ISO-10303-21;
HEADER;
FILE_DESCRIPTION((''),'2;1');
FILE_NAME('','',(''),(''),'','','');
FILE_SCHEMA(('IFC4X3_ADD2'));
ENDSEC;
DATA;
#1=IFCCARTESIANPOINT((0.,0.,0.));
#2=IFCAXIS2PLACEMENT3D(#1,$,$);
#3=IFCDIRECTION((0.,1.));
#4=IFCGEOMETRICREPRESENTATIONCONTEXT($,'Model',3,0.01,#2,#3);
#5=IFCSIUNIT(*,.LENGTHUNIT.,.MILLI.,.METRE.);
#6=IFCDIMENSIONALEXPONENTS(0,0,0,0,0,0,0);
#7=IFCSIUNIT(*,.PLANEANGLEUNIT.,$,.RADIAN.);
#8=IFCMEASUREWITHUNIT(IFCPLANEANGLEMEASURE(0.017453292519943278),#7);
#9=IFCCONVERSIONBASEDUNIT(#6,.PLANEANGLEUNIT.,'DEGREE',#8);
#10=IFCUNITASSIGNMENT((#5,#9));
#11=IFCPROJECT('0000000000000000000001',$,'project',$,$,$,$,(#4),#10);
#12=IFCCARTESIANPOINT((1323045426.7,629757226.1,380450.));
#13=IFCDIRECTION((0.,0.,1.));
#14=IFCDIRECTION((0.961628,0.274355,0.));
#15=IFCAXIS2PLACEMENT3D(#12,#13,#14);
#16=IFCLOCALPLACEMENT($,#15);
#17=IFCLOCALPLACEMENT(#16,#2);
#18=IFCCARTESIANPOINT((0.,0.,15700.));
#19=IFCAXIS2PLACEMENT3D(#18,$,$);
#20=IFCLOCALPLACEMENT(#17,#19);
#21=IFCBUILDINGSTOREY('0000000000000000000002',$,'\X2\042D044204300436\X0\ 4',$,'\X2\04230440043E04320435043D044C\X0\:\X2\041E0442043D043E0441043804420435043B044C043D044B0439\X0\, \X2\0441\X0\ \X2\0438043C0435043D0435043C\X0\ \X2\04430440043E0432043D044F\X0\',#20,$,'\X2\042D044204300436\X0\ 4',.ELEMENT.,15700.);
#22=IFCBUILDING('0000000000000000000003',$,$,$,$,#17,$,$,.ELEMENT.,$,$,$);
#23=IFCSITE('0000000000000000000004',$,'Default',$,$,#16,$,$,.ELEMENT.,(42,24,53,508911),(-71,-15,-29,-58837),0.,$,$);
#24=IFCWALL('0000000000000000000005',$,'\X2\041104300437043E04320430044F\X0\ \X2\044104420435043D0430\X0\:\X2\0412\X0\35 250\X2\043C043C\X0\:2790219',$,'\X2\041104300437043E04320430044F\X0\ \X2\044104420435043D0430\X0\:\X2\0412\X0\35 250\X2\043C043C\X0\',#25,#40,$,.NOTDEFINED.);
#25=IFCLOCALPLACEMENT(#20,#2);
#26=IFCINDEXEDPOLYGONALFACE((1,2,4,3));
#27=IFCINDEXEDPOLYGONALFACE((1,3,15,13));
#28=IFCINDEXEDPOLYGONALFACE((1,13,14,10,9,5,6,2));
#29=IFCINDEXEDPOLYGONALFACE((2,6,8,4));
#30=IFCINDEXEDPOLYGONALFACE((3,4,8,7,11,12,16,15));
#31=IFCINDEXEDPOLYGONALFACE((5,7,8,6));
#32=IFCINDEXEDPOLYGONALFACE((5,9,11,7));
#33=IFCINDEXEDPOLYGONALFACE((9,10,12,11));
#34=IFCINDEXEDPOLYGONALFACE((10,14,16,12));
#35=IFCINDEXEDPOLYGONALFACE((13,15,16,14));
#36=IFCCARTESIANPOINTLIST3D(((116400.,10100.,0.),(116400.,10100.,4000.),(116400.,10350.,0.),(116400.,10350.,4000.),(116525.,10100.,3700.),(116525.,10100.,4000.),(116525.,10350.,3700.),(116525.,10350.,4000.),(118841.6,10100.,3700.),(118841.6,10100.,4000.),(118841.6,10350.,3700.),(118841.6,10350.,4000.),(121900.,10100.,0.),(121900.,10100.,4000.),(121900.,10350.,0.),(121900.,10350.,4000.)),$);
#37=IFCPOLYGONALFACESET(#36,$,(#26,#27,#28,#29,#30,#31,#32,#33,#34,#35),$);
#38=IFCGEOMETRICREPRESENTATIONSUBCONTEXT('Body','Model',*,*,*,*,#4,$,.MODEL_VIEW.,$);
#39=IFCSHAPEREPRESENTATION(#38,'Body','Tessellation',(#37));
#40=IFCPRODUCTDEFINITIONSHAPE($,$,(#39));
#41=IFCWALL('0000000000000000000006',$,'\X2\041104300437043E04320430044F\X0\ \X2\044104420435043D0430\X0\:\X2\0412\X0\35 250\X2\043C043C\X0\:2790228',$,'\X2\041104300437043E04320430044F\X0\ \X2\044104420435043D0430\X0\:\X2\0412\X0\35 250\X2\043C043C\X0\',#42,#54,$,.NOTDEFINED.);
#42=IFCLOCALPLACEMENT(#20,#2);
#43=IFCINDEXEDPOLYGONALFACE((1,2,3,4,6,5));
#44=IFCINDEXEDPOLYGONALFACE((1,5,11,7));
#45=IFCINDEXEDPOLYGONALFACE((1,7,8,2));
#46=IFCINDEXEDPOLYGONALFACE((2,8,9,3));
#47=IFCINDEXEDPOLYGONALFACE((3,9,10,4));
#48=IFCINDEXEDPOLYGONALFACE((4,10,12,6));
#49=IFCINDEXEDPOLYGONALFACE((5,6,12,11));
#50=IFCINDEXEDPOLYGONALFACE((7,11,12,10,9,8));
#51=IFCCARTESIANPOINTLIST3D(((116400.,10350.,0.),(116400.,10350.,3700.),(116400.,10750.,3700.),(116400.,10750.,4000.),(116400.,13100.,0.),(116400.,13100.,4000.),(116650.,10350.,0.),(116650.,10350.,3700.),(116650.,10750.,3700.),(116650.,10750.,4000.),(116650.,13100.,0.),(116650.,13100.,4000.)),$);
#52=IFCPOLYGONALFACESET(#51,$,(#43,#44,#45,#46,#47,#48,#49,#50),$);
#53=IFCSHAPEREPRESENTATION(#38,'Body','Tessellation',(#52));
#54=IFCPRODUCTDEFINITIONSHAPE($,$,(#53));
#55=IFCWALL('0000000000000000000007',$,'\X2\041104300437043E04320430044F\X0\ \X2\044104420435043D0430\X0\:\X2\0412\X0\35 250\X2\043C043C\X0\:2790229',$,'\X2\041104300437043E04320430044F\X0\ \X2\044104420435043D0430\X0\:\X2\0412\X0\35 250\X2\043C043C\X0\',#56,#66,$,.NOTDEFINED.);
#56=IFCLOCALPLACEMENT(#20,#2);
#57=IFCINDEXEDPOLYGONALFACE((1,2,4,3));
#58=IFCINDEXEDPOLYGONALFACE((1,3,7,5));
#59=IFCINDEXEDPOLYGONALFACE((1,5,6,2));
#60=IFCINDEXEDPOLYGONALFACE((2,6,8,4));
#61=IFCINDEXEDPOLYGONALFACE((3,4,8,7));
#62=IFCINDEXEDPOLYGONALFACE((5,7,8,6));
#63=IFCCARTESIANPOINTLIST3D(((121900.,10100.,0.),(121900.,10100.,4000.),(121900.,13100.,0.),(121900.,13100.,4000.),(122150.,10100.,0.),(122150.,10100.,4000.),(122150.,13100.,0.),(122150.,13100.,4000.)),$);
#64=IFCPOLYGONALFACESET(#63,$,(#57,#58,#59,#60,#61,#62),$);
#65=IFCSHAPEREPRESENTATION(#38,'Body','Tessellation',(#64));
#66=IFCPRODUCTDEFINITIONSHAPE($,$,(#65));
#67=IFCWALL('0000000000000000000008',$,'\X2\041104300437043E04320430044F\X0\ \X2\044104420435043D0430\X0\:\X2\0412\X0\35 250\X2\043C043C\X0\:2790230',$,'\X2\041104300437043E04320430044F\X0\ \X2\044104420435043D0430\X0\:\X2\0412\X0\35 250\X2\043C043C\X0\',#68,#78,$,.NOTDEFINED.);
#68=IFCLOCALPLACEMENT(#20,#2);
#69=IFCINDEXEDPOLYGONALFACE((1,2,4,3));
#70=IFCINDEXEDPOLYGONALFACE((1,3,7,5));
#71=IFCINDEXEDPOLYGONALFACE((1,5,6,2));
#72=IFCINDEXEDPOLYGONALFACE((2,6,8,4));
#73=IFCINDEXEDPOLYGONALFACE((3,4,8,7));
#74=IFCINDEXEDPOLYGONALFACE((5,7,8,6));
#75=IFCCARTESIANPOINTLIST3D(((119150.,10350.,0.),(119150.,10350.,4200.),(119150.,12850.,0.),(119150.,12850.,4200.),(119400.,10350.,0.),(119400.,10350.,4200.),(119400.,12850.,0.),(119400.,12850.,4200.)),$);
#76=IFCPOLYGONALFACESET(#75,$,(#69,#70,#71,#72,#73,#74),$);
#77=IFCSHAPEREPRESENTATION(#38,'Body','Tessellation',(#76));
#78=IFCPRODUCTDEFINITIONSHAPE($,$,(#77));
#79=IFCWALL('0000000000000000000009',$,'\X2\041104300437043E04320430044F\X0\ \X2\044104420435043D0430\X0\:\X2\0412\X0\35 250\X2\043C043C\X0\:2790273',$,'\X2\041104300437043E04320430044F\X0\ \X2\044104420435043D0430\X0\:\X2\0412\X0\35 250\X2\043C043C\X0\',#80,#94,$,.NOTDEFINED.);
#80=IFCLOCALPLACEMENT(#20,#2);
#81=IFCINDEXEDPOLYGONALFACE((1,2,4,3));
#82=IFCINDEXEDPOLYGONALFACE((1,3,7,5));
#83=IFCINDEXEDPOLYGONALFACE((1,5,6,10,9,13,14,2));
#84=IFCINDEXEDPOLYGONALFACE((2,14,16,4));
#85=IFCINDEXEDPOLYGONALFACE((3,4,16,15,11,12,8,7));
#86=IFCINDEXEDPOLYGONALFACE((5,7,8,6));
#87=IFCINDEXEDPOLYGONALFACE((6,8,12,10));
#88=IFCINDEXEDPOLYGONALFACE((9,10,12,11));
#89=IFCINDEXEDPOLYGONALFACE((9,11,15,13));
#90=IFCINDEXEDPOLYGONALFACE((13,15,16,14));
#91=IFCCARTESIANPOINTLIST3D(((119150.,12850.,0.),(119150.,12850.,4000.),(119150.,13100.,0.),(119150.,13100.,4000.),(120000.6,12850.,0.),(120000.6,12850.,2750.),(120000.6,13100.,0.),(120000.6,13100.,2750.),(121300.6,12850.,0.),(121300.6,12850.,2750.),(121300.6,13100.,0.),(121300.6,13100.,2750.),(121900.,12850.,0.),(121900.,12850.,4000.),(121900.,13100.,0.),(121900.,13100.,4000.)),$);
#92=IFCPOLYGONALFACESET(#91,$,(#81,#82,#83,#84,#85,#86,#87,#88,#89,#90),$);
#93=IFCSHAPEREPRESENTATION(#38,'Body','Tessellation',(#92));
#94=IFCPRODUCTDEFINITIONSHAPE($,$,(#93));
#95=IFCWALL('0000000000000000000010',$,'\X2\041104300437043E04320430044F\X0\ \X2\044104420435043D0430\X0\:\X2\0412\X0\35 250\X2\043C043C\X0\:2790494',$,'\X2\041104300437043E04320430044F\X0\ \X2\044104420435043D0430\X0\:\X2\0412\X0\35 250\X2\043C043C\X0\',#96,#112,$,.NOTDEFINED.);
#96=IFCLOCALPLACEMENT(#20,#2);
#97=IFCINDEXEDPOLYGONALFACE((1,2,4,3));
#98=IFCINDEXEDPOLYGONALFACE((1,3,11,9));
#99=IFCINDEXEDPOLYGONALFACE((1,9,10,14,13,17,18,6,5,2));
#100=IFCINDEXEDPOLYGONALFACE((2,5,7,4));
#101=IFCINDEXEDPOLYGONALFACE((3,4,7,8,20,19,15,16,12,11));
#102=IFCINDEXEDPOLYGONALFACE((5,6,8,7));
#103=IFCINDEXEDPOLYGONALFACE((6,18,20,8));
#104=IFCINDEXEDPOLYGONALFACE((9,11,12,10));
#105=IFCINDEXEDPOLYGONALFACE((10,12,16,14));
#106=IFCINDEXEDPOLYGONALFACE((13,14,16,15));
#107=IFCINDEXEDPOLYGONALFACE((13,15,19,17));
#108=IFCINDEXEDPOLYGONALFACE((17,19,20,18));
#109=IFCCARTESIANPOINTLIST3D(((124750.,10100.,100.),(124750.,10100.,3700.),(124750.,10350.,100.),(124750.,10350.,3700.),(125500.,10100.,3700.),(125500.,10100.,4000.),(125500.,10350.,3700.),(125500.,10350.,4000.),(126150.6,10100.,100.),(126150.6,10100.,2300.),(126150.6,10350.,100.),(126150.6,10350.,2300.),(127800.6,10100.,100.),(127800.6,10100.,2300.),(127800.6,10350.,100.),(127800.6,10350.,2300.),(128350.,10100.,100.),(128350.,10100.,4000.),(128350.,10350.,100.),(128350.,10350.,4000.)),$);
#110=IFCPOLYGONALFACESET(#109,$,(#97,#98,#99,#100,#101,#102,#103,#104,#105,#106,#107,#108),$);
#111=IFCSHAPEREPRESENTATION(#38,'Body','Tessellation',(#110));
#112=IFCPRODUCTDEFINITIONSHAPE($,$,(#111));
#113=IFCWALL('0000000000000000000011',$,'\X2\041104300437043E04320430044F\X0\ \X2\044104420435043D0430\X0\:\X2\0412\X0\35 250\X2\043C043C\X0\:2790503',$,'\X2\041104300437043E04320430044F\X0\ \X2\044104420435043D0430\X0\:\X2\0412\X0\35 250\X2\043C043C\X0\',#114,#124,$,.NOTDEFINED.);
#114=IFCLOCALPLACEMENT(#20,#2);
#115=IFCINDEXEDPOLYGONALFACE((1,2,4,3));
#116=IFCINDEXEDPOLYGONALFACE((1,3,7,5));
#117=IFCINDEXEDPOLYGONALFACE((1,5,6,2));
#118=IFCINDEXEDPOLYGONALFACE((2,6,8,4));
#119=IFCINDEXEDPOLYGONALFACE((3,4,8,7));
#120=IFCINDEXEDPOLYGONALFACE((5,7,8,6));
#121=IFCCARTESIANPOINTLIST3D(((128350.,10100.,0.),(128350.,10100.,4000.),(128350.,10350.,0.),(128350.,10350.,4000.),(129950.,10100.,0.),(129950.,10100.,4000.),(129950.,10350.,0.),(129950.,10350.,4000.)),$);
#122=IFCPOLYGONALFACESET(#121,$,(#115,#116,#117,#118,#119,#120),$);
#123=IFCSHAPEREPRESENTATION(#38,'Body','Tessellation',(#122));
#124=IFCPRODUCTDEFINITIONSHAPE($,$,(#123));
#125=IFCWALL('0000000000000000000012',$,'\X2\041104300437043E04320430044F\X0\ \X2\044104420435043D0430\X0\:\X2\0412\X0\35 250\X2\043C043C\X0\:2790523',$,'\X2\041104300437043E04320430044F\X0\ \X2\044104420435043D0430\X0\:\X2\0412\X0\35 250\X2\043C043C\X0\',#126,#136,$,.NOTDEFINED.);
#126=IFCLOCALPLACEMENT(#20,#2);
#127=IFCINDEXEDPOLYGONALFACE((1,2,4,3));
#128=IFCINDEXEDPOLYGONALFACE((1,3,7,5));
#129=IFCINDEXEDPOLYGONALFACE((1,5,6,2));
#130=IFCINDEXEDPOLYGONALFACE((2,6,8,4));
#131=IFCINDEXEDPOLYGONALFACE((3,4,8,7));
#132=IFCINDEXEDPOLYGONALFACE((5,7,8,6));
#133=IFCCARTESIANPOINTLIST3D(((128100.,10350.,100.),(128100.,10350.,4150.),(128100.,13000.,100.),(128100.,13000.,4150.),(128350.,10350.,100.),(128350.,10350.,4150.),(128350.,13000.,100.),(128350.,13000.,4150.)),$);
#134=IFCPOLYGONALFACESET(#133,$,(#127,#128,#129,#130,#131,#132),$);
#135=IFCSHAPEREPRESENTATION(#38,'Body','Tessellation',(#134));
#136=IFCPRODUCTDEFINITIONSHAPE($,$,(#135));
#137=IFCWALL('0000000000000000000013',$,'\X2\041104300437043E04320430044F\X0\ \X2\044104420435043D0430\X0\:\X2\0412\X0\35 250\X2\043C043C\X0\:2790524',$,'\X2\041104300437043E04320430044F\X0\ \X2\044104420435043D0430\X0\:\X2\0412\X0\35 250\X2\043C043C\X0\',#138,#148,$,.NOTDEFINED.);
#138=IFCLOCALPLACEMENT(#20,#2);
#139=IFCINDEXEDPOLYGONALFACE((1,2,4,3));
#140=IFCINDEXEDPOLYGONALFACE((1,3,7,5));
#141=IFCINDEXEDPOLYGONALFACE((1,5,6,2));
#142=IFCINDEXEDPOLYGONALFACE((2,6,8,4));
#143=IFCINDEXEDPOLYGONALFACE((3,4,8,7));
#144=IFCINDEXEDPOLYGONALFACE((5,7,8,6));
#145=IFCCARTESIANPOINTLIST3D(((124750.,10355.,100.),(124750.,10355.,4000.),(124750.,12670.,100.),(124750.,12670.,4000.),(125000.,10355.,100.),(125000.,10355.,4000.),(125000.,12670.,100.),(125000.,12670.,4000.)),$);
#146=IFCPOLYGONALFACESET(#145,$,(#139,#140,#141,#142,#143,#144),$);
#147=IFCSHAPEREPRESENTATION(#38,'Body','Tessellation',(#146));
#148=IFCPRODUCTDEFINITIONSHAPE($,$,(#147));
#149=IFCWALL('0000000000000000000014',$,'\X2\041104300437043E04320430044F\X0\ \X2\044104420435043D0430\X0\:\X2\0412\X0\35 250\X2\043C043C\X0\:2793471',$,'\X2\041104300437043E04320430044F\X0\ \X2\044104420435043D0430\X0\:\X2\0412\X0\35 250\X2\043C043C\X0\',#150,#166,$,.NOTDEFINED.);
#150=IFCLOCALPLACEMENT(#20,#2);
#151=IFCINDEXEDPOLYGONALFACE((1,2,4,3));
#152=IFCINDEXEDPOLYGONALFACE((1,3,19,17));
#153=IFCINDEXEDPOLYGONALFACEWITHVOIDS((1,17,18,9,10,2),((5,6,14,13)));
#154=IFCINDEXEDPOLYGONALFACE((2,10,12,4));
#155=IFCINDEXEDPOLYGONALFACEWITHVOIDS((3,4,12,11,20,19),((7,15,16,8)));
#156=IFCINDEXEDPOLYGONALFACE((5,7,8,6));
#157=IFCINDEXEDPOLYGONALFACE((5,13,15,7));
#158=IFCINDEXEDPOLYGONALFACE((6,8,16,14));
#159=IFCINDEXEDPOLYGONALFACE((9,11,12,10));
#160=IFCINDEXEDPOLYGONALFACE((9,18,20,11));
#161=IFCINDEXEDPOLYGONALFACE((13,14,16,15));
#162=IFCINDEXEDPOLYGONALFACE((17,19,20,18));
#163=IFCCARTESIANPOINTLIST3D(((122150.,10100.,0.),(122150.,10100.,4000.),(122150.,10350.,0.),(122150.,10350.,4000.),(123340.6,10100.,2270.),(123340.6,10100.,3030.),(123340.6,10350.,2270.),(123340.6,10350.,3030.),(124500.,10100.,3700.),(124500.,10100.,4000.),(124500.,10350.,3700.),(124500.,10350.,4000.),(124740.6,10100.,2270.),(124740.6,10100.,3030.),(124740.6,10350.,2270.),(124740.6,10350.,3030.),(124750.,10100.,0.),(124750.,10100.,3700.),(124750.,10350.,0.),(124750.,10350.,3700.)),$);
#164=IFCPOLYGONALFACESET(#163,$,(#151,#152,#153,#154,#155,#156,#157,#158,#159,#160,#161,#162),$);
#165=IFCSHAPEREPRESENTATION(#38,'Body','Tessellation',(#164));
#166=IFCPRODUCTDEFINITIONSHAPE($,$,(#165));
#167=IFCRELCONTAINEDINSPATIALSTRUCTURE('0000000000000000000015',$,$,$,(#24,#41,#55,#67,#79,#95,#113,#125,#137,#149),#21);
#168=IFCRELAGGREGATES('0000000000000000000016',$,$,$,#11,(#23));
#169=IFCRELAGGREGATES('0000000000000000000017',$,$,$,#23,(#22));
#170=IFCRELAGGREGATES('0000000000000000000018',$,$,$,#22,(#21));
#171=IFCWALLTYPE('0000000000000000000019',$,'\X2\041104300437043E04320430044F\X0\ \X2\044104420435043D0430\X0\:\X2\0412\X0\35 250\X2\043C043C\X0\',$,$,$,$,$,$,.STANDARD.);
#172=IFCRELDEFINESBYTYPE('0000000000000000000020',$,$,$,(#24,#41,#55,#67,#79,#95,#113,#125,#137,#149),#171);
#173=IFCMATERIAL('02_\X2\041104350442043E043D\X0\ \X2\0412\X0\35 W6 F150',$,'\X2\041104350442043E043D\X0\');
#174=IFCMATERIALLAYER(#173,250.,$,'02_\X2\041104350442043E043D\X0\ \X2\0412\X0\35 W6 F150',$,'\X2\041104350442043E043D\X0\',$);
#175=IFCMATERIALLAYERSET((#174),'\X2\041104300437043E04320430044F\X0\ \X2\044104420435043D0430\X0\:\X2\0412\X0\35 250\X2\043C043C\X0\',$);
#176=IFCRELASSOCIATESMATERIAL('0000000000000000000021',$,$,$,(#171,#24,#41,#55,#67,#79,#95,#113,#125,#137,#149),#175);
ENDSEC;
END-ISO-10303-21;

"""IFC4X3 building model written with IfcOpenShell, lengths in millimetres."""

from ifc_helpers import new_model, entity, si_unit, converted_unit, direction, frame, frame_2d, origin, place, context, subcontext, project, spatial, rectangle, extrude, material, layer, layer_set, type_object, element, save


model = new_model("IFC4X3")

# Units and contexts
model_context = context("Model", 3, precision=0.01, world=origin(), true_north=direction((0.0, 1.0)))
body_context = subcontext(model_context, "Body", "Model", "MODEL_VIEW")
ifc_project = project(units=[si_unit("LENGTHUNIT", "METRE", prefix="MILLI"), converted_unit("PLANEANGLEUNIT", "DEGREE", entity("IfcPlaneAngleMeasure", 0.017453292519943278), si_unit("PLANEANGLEUNIT", "RADIAN"), dimensions=[0, 0, 0, 0, 0, 0, 0])], contexts=[model_context])

# Site, building, storey
site_placement = place(None, frame((1323045426.7, 629757226.1, 380450.0), z_axis=(0.0, 0.0, 1.0), x_axis=(0.961628, 0.274355, 0.0)))
site = spatial("IfcSite", under=ifc_project, at=site_placement, Name="Default", CompositionType="ELEMENT", RefLatitude=(42, 24, 53, 508911), RefLongitude=(-71, -15, -29, -58837), RefElevation=0.0)
building_placement = place(site_placement, origin())
building = spatial("IfcBuilding", under=site, at=building_placement, CompositionType="ELEMENT")
storey_placement = place(building_placement, frame((0.0, 0.0, 15700.0)))
storey = spatial("IfcBuildingStorey", under=building, at=storey_placement, Name="Этаж 4", ObjectType="Уровень:Относительный, с именем уровня", LongName="Этаж 4", CompositionType="ELEMENT", Elevation=15700.0)

# Wall, opening
ifc_material = material(Name="02_Бетон В35 W6 F150", Category="Бетон")
ifc_layer_1 = layer(ifc_material, 250.0, Name="02_Бетон В35 W6 F150", Category="Бетон")
ifc_layer_set_1 = layer_set([ifc_layer_1], Name="Базовая стена:В35 250мм")
wall_type_1 = type_object("IfcWallType", Name="Базовая стена:В35 250мм", PredefinedType="STANDARD", material=ifc_layer_set_1)
wall_1_placement = place(storey_placement, frame((116400.0, 10225.0, 0.0)))
wall_1 = element("IfcWall", 1, at=wall_1_placement, inside=storey, type_object=wall_type_1, material=ifc_layer_set_1, Name="Базовая стена:В35 250мм:2790219", ObjectType="Базовая стена:В35 250мм", PredefinedType="NOTDEFINED", context=body_context, shape_type="SweptSolid", body=[
    extrude(rectangle(XDim=5500.0, YDim=250.0, at=frame_2d((2750.0, 0.0), x_axis=(-1.0, 0.0))), origin(), (0.0, 0.0, 1.0), 4000.0),
])
opening_1_placement = place(wall_1_placement, origin())
element("IfcOpeningElement", 2, at=opening_1_placement, cuts=wall_1, PredefinedType="OPENING", context=body_context, shape_type="SweptSolid", body=[
    extrude(rectangle(XDim=300.0, YDim=2316.6, at=frame_2d((0.0, 0.0), x_axis=(0.0, 1.0))), frame((1283.3, 125.0, 3850.0), z_axis=(0.0, -1.0, 0.0), x_axis=(-1.0, 0.0, 0.0)), (0.0, 0.0, 1.0), 250.0),
])

# Wall, opening
wall_2_placement = place(storey_placement, frame((116525.0, 10350.0, 0.0), z_axis=(0.0, 0.0, 1.0), x_axis=(0.0, 1.0, 0.0)))
wall_2 = element("IfcWall", 3, at=wall_2_placement, inside=storey, type_object=wall_type_1, material=ifc_layer_set_1, Name="Базовая стена:В35 250мм:2790228", ObjectType="Базовая стена:В35 250мм", PredefinedType="NOTDEFINED", context=body_context, shape_type="SweptSolid", body=[
    extrude(rectangle(XDim=2750.0, YDim=250.0, at=frame_2d((1375.0, 0.0), x_axis=(-1.0, 0.0))), origin(), (0.0, 0.0, 1.0), 4000.0),
])
opening_2_placement = place(wall_2_placement, origin())
element("IfcOpeningElement", 4, at=opening_2_placement, cuts=wall_2, PredefinedType="OPENING", context=body_context, shape_type="SweptSolid", body=[
    extrude(rectangle(XDim=300.0, YDim=525.0, at=frame_2d((0.0, 0.0), x_axis=(0.0, 1.0))), frame((137.5, 125.0, 3850.0), z_axis=(0.0, -1.0, 0.0), x_axis=(-1.0, 0.0, 0.0)), (0.0, 0.0, 1.0), 250.0),
])

# Walls
wall_3_placement = place(storey_placement, frame((122025.0, 13100.0, 0.0), z_axis=(0.0, 0.0, 1.0), x_axis=(0.0, -1.0, 0.0)))
element("IfcWall", 5, at=wall_3_placement, inside=storey, type_object=wall_type_1, material=ifc_layer_set_1, Name="Базовая стена:В35 250мм:2790229", ObjectType="Базовая стена:В35 250мм", PredefinedType="NOTDEFINED", context=body_context, shape_type="SweptSolid", body=[
    extrude(rectangle(XDim=3000.0, YDim=250.0, at=frame_2d((1500.0, 0.0), x_axis=(-1.0, 0.0))), origin(), (0.0, 0.0, 1.0), 4000.0),
])
wall_4_placement = place(storey_placement, frame((119275.0, 12850.0, 0.0), z_axis=(0.0, 0.0, 1.0), x_axis=(0.0, -1.0, 0.0)))
element("IfcWall", 6, at=wall_4_placement, inside=storey, type_object=wall_type_1, material=ifc_layer_set_1, Name="Базовая стена:В35 250мм:2790230", ObjectType="Базовая стена:В35 250мм", PredefinedType="NOTDEFINED", context=body_context, shape_type="SweptSolid", body=[
    extrude(rectangle(XDim=2500.0, YDim=250.0, at=frame_2d((1250.0, 0.0), x_axis=(-1.0, 0.0))), origin(), (0.0, 0.0, 1.0), 4200.0),
])

# Wall, opening
wall_5_placement = place(storey_placement, frame((119150.0, 12975.0, 0.0)))
wall_5 = element("IfcWall", 7, at=wall_5_placement, inside=storey, type_object=wall_type_1, material=ifc_layer_set_1, Name="Базовая стена:В35 250мм:2790273", ObjectType="Базовая стена:В35 250мм", PredefinedType="NOTDEFINED", context=body_context, shape_type="SweptSolid", body=[
    extrude(rectangle(XDim=2750.0, YDim=250.0, at=frame_2d((1375.0, 0.0), x_axis=(1.0, 0.0))), origin(), (0.0, 0.0, 1.0), 4000.0),
])
opening_3_placement = place(wall_5_placement, frame((-119150.0, -12975.0, 0.0)))
element("IfcOpeningElement", 8, at=opening_3_placement, cuts=wall_5, PredefinedType="OPENING", context=body_context, shape_type="SweptSolid", body=[
    extrude(rectangle(XDim=2750.0, YDim=1300.0, at=frame_2d((0.0, 0.0), x_axis=(1.0, 0.0))), frame((120650.6, 11326.0, 1375.0), z_axis=(0.0, 1.0, 0.0), x_axis=(0.0, 0.0, -1.0)), (0.0, 0.0, 1.0), 3048.0),
])

# Wall, openings
wall_6_placement = place(storey_placement, frame((124750.0, 10225.0, 100.0)))
wall_6 = element("IfcWall", 9, at=wall_6_placement, inside=storey, type_object=wall_type_1, material=ifc_layer_set_1, Name="Базовая стена:В35 250мм:2790494", ObjectType="Базовая стена:В35 250мм", PredefinedType="NOTDEFINED", context=body_context, shape_type="SweptSolid", body=[
    extrude(rectangle(XDim=3600.0, YDim=250.0, at=frame_2d((1800.0, 0.0), x_axis=(-1.0, 0.0))), origin(), (0.0, 0.0, 1.0), 3900.0),
])
opening_4_placement = place(wall_6_placement, origin())
element("IfcOpeningElement", 10, at=opening_4_placement, cuts=wall_6, PredefinedType="OPENING", context=body_context, shape_type="SweptSolid", body=[
    extrude(rectangle(XDim=300.0, YDim=750.0, at=frame_2d((0.0, 0.0), x_axis=(0.0, 1.0))), frame((375.0, 125.0, 3750.0), z_axis=(0.0, -1.0, 0.0), x_axis=(-1.0, 0.0, 0.0)), (0.0, 0.0, 1.0), 250.0),
])
opening_5_placement = place(wall_6_placement, frame((-124750.0, -10225.0, 0.0)))
element("IfcOpeningElement", 11, at=opening_5_placement, cuts=wall_6, PredefinedType="OPENING", context=body_context, shape_type="SweptSolid", body=[
    extrude(rectangle(XDim=2200.0, YDim=1650.0, at=frame_2d((0.0, 0.0), x_axis=(0.0, 1.0))), frame((126975.6, 8826.0, 1100.0), z_axis=(0.0, 1.0, 0.0), x_axis=(1.0, 0.0, 0.0)), (0.0, 0.0, 1.0), 3048.0),
])

# Walls
wall_7_placement = place(storey_placement, frame((128350.0, 10225.0, 0.0)))
element("IfcWall", 12, at=wall_7_placement, inside=storey, type_object=wall_type_1, material=ifc_layer_set_1, Name="Базовая стена:В35 250мм:2790503", ObjectType="Базовая стена:В35 250мм", PredefinedType="NOTDEFINED", context=body_context, shape_type="SweptSolid", body=[
    extrude(rectangle(XDim=1600.0, YDim=250.0, at=frame_2d((800.0, 0.0), x_axis=(-1.0, 0.0))), origin(), (0.0, 0.0, 1.0), 4000.0),
])
wall_8_placement = place(storey_placement, frame((128225.0, 13000.0, 100.0), z_axis=(0.0, 0.0, 1.0), x_axis=(0.0, -1.0, 0.0)))
element("IfcWall", 13, at=wall_8_placement, inside=storey, type_object=wall_type_1, material=ifc_layer_set_1, Name="Базовая стена:В35 250мм:2790523", ObjectType="Базовая стена:В35 250мм", PredefinedType="NOTDEFINED", context=body_context, shape_type="SweptSolid", body=[
    extrude(rectangle(XDim=2650.0, YDim=250.0, at=frame_2d((1325.0, 0.0), x_axis=(-1.0, 0.0))), origin(), (0.0, 0.0, 1.0), 4050.0),
])
wall_9_placement = place(storey_placement, frame((124875.0, 12670.0, 100.0), z_axis=(0.0, 0.0, 1.0), x_axis=(0.0, -1.0, 0.0)))
element("IfcWall", 14, at=wall_9_placement, inside=storey, type_object=wall_type_1, material=ifc_layer_set_1, Name="Базовая стена:В35 250мм:2790524", ObjectType="Базовая стена:В35 250мм", PredefinedType="NOTDEFINED", context=body_context, shape_type="SweptSolid", body=[
    extrude(rectangle(XDim=2315.0, YDim=250.0, at=frame_2d((1157.5, 0.0), x_axis=(-1.0, 0.0))), origin(), (0.0, 0.0, 1.0), 3900.0),
])

# Wall, openings
wall_10_placement = place(storey_placement, frame((122150.0, 10225.0, 0.0)))
wall_10 = element("IfcWall", 15, at=wall_10_placement, inside=storey, type_object=wall_type_1, material=ifc_layer_set_1, Name="Базовая стена:В35 250мм:2793471", ObjectType="Базовая стена:В35 250мм", PredefinedType="NOTDEFINED", context=body_context, shape_type="SweptSolid", body=[
    extrude(rectangle(XDim=2600.0, YDim=250.0, at=frame_2d((1300.0, 0.0), x_axis=(-1.0, 0.0))), origin(), (0.0, 0.0, 1.0), 4000.0),
])
opening_6_placement = place(wall_10_placement, origin())
element("IfcOpeningElement", 16, at=opening_6_placement, cuts=wall_10, PredefinedType="OPENING", context=body_context, shape_type="SweptSolid", body=[
    extrude(rectangle(XDim=300.0, YDim=250.0, at=frame_2d((0.0, 0.0), x_axis=(1.0, 0.0))), frame((2475.0, 125.0, 3850.0), z_axis=(0.0, -1.0, 0.0), x_axis=(0.0, 0.0, 1.0)), (0.0, 0.0, 1.0), 250.0),
])
opening_7_placement = place(wall_10_placement, frame((-122150.0, -10225.0, 2270.0)))
element("IfcOpeningElement", 17, at=opening_7_placement, cuts=wall_10, PredefinedType="OPENING", context=body_context, shape_type="SweptSolid", body=[
    extrude(rectangle(XDim=760.0, YDim=1400.0, at=frame_2d((0.0, 0.0), x_axis=(0.0, 1.0))), frame((124040.6, 8576.0, 380.0), z_axis=(0.0, 1.0, 0.0), x_axis=(1.0, 0.0, 0.0)), (0.0, 0.0, 1.0), 3048.0),
])

save(model, "model.ifc")
